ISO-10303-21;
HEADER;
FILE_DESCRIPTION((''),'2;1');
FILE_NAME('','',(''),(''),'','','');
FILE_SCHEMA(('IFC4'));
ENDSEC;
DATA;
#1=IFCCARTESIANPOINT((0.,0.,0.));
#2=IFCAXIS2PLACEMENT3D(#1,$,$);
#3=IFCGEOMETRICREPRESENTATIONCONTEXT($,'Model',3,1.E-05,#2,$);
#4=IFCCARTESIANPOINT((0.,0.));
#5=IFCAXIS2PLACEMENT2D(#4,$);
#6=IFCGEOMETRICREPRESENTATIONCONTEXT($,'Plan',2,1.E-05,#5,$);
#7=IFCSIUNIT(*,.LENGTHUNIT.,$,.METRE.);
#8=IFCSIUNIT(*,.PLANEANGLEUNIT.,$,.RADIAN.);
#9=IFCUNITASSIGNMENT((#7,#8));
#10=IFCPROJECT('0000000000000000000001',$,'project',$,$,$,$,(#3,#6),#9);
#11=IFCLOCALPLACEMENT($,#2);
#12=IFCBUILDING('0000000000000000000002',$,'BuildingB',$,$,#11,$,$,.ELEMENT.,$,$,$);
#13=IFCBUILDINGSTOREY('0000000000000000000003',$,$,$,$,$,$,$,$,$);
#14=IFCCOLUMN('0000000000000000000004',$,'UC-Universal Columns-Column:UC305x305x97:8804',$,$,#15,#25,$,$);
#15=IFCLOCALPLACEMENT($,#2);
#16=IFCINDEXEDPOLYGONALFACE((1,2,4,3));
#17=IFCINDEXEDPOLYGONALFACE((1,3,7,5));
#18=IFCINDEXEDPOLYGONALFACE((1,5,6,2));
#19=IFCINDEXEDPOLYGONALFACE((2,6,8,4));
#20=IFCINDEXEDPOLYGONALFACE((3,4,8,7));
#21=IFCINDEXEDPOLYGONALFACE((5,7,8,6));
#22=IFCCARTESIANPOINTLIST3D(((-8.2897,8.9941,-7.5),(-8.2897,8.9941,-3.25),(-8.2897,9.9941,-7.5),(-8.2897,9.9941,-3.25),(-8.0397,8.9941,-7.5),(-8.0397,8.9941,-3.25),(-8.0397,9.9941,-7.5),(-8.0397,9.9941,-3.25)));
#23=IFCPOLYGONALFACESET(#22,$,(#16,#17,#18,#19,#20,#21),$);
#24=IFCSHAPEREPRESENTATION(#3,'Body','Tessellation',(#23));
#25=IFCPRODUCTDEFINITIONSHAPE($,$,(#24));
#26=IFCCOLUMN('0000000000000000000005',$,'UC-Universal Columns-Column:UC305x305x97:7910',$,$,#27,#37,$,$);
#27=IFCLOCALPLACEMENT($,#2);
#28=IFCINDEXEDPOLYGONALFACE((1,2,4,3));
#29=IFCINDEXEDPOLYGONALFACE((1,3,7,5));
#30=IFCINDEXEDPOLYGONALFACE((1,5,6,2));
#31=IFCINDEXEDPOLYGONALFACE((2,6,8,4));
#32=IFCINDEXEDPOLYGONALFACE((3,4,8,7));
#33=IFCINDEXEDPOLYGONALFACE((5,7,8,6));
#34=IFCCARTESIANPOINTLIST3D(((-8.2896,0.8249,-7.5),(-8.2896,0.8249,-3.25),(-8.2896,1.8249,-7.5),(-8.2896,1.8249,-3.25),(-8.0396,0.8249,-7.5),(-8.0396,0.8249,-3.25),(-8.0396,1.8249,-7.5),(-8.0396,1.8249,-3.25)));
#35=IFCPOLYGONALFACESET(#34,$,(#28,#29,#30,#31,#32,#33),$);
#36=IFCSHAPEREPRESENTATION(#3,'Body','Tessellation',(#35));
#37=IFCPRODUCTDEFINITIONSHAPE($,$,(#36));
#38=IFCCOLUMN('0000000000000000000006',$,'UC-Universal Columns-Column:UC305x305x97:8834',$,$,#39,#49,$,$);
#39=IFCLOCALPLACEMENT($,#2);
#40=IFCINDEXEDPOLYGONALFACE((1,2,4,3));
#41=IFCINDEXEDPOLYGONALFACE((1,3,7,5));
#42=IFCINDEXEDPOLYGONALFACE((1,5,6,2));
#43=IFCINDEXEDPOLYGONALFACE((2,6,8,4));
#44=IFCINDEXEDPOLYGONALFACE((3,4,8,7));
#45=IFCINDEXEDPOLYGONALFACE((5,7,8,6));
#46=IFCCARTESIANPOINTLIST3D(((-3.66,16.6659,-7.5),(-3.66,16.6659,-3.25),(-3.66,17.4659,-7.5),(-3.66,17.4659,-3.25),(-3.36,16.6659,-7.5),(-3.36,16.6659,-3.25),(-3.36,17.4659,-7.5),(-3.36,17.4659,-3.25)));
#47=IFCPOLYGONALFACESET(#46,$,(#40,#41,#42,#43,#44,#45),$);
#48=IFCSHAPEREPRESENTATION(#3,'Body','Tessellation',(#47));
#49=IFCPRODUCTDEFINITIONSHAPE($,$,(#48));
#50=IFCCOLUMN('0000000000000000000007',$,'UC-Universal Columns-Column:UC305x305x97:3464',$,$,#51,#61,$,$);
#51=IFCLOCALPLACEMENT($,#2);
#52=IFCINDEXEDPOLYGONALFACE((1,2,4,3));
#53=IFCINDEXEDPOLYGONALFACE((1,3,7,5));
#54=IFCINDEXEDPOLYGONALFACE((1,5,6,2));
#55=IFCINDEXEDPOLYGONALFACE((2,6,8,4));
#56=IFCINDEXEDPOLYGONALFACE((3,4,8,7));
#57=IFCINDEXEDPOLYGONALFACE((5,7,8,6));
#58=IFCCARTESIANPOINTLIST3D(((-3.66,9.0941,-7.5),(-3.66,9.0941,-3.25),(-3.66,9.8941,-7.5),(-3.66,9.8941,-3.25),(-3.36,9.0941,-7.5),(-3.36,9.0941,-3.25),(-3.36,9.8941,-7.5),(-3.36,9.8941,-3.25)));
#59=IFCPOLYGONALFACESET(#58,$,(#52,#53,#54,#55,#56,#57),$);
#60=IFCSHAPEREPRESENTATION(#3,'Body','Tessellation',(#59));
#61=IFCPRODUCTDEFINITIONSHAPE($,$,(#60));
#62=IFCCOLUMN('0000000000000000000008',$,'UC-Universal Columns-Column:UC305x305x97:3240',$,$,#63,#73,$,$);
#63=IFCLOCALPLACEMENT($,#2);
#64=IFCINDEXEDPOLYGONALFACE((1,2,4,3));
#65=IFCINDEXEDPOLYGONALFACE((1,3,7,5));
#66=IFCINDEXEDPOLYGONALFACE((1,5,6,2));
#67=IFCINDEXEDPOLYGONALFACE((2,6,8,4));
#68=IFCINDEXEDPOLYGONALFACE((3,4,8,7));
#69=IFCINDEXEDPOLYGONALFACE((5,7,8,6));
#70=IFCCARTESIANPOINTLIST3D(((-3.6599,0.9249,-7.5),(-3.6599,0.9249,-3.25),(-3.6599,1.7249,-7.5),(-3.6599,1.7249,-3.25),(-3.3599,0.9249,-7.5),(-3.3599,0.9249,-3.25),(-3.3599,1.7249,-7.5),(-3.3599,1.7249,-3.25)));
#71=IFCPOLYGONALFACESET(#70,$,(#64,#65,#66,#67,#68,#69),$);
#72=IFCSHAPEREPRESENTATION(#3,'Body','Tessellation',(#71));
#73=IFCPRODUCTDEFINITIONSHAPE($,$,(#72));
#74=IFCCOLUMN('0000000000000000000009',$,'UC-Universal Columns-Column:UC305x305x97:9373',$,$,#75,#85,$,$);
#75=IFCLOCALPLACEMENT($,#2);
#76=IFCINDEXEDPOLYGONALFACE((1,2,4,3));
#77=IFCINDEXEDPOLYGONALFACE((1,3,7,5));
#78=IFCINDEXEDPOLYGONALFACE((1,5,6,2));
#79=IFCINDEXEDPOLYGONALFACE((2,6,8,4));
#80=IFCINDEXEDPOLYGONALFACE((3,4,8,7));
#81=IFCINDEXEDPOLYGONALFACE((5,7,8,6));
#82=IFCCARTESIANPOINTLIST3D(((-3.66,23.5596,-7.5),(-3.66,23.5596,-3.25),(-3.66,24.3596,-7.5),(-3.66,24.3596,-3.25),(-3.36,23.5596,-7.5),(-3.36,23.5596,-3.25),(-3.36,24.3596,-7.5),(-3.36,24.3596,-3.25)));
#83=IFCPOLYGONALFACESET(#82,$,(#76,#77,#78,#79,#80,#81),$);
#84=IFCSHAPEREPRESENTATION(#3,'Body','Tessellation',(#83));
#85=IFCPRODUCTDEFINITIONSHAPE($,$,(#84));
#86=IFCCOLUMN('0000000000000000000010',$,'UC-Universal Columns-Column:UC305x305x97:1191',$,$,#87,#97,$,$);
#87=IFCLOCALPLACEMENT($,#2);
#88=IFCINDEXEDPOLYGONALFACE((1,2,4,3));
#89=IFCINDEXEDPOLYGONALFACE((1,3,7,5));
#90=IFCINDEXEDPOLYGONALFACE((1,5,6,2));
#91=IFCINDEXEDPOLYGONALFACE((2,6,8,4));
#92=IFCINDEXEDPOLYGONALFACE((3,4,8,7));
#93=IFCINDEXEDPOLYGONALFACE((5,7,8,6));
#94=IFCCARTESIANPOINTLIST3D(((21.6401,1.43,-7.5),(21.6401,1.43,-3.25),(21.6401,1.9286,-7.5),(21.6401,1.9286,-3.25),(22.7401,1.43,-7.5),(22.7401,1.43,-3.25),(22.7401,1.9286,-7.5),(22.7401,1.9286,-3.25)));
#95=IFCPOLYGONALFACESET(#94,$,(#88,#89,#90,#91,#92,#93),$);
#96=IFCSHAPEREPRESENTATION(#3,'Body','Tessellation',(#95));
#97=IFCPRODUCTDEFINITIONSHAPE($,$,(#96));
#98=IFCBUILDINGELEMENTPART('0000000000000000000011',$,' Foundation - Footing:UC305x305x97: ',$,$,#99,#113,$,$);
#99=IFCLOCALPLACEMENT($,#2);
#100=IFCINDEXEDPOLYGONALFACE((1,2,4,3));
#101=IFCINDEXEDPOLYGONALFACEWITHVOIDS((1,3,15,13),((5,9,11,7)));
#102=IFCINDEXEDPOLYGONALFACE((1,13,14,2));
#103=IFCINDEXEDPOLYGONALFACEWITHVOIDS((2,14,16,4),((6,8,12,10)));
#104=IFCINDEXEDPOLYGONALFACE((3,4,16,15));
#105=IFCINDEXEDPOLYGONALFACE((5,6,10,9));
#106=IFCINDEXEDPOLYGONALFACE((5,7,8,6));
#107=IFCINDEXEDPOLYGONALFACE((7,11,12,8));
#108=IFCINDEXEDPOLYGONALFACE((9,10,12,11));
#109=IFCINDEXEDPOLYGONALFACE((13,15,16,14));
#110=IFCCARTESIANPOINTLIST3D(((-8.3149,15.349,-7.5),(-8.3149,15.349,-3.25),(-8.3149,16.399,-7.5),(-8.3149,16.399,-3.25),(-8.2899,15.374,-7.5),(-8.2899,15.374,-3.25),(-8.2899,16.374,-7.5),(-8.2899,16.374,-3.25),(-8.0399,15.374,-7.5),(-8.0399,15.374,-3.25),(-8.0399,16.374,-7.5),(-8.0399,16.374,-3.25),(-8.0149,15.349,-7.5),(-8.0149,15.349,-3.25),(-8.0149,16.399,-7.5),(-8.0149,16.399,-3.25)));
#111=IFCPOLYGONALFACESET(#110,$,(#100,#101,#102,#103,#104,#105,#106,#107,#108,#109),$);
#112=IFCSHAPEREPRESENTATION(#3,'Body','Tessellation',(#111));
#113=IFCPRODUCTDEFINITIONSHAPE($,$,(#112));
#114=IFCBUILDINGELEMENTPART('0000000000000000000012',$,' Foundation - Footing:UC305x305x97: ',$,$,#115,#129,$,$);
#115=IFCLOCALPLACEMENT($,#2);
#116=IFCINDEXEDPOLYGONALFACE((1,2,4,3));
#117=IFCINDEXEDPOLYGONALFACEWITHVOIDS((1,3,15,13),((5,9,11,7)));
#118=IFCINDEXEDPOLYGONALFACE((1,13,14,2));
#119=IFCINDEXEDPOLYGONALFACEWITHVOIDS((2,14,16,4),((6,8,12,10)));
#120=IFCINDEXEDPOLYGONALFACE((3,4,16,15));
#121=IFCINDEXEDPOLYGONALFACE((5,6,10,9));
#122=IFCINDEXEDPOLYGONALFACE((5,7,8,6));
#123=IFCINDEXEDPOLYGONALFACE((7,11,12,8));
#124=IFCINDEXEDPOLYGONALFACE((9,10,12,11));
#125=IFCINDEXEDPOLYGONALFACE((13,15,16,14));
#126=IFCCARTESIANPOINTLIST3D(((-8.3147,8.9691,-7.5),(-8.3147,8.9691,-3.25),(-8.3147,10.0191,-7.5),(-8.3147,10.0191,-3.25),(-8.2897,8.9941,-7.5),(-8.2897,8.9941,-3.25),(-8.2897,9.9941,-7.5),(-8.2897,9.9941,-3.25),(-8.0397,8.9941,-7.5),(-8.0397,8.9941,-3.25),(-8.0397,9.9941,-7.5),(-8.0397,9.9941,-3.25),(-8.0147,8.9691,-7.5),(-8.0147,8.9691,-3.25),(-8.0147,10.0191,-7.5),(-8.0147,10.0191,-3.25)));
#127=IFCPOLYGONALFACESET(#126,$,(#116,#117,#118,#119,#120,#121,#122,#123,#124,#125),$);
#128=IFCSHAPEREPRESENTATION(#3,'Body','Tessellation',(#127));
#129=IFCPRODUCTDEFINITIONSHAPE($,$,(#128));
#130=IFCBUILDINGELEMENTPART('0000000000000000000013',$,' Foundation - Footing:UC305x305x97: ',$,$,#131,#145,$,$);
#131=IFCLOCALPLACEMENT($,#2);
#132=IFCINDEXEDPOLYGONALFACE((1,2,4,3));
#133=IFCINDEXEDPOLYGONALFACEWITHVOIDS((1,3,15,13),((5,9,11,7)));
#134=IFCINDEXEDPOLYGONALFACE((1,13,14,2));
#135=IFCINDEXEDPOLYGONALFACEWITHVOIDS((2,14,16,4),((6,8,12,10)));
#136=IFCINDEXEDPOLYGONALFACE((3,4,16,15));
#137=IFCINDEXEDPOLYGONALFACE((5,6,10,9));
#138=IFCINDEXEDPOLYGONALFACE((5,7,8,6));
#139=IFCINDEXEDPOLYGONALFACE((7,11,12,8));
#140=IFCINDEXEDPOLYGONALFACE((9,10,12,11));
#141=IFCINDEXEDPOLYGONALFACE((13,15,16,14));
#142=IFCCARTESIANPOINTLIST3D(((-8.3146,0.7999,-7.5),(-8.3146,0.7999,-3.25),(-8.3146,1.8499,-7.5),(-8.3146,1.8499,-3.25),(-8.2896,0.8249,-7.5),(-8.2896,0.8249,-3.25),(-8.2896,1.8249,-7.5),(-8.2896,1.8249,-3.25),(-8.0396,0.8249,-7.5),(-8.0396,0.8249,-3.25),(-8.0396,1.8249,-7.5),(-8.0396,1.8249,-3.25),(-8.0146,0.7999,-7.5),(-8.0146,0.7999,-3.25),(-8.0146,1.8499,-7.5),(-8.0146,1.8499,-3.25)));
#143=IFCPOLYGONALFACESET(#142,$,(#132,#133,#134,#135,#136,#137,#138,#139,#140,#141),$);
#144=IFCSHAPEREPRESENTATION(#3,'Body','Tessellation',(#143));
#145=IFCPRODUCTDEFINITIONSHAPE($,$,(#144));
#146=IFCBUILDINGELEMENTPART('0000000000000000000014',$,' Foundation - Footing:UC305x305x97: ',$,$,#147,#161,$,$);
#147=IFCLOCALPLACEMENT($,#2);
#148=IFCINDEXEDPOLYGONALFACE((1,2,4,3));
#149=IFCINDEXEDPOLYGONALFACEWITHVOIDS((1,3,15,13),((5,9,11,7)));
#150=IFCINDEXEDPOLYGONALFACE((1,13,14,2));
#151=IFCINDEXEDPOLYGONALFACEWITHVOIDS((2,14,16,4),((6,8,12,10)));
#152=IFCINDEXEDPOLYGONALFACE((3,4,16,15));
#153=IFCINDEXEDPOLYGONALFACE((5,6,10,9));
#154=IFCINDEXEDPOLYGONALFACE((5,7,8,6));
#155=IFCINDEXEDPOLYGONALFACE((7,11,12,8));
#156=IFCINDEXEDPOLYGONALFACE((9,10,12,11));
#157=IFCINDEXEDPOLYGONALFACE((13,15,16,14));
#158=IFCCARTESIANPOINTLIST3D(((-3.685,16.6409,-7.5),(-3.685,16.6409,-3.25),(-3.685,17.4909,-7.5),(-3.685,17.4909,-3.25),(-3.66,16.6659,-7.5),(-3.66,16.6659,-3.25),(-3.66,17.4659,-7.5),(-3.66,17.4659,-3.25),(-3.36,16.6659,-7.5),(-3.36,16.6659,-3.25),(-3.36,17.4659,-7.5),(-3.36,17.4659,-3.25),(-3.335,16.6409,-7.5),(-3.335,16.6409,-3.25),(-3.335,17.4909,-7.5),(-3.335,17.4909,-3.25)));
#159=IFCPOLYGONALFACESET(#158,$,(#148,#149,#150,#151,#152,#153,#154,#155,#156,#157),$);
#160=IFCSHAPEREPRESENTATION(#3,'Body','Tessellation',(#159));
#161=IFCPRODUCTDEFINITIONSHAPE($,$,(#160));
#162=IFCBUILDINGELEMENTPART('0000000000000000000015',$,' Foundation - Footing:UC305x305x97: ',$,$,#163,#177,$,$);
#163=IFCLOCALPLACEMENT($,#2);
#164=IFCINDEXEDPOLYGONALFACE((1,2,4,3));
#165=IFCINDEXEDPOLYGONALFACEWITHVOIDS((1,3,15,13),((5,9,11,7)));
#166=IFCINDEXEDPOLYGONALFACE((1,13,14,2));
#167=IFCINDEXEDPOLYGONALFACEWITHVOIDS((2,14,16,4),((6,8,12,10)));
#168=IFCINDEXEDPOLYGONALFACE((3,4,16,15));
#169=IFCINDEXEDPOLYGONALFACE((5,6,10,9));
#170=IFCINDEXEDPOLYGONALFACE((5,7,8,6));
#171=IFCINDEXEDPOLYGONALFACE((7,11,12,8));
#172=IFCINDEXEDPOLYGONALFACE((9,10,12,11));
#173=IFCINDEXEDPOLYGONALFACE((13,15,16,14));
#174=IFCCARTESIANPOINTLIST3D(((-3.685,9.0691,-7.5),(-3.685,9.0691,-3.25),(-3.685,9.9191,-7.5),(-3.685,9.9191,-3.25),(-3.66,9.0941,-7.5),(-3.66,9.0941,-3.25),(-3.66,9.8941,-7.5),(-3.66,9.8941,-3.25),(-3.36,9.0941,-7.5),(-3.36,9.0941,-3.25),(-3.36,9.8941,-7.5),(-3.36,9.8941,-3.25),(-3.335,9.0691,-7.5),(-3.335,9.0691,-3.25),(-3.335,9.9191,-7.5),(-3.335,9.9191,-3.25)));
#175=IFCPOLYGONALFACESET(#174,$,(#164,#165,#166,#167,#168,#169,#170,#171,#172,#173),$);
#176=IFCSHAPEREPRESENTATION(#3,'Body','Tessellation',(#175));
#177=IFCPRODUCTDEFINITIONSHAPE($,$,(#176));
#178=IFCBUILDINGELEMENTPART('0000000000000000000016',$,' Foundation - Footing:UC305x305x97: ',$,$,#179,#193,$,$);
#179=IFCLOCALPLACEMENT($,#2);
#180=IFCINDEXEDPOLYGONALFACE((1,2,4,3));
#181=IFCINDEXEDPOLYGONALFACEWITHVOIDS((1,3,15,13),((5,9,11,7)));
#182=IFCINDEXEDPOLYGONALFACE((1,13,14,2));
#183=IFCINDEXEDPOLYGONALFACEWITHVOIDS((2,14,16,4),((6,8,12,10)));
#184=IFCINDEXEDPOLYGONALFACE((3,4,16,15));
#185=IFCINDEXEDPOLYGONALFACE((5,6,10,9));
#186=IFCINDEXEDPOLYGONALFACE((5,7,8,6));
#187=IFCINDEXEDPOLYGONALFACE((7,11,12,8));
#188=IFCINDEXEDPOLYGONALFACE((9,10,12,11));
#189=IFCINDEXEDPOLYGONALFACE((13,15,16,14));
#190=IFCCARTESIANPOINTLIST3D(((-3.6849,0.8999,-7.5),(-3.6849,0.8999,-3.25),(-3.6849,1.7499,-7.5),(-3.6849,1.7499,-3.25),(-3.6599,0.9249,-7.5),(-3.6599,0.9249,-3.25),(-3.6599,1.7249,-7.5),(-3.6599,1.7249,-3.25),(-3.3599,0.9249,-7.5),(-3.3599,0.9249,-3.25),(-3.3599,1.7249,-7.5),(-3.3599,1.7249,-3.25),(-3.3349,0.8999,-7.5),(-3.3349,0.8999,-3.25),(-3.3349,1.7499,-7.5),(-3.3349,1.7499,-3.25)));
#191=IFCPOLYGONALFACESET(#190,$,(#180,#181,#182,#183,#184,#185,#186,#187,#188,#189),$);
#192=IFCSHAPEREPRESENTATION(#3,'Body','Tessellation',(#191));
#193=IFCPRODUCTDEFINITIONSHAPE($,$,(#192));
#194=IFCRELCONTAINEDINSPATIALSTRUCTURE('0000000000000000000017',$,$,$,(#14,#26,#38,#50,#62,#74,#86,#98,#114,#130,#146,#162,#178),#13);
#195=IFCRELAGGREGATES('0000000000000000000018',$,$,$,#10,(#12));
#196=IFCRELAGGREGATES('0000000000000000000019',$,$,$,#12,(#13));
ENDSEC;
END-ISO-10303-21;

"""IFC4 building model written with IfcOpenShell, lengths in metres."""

from ifc_helpers import new_model, si_unit, origin, origin_2d, place, context, project, spatial, polyline, outline, extrude, element, save


model = new_model("IFC4")

# Units and contexts
model_context = context("Model", 3, precision=1e-05, world=origin())
plan_context = context("Plan", 2, precision=1e-05, world=origin_2d())
ifc_project = project(units=[si_unit("LENGTHUNIT", "METRE"), si_unit("PLANEANGLEUNIT", "RADIAN")], contexts=[model_context, plan_context])

# Building, storey
building_placement = place(None, origin())
building = spatial("IfcBuilding", under=ifc_project, at=building_placement, Name="BuildingB", CompositionType="ELEMENT")
storey = spatial("IfcBuildingStorey", under=building)

# Columns
element("IfcColumn", 1, inside=storey, Name="UC-Universal Columns-Column:UC305x305x97:8804", context=model_context, shape_type="SweptSolid", body=[
    extrude(outline(polyline([(-8.0397, 9.9941, -7.5), (-8.2897, 9.9941, -7.5), (-8.2897, 8.9941, -7.5), (-8.0397, 8.9941, -7.5), (-8.0397, 9.9941, -7.5)])), None, (0.0, 0.0, 1.0), 4.25),
])
element("IfcColumn", 2, inside=storey, Name="UC-Universal Columns-Column:UC305x305x97:7910", context=model_context, shape_type="SweptSolid", body=[
    extrude(outline(polyline([(-8.0396, 1.8249, -7.5), (-8.2896, 1.8249, -7.5), (-8.2896, 0.8249, -7.5), (-8.0396, 0.8249, -7.5), (-8.0396, 1.8249, -7.5)])), None, (0.0, 0.0, 1.0), 4.25),
])
element("IfcColumn", 3, inside=storey, Name="UC-Universal Columns-Column:UC305x305x97:8834", context=model_context, shape_type="SweptSolid", body=[
    extrude(outline(polyline([(-3.36, 17.4659, -7.5), (-3.66, 17.4659, -7.5), (-3.66, 16.6659, -7.5), (-3.36, 16.6659, -7.5), (-3.36, 17.4659, -7.5)])), None, (0.0, 0.0, 1.0), 4.25),
])
element("IfcColumn", 4, inside=storey, Name="UC-Universal Columns-Column:UC305x305x97:3464", context=model_context, shape_type="SweptSolid", body=[
    extrude(outline(polyline([(-3.36, 9.8941, -7.5), (-3.66, 9.8941, -7.5), (-3.66, 9.0941, -7.5), (-3.36, 9.0941, -7.5), (-3.36, 9.8941, -7.5)])), None, (0.0, 0.0, 1.0), 4.25),
])
element("IfcColumn", 5, inside=storey, Name="UC-Universal Columns-Column:UC305x305x97:3240", context=model_context, shape_type="SweptSolid", body=[
    extrude(outline(polyline([(-3.3599, 1.7249, -7.5), (-3.6599, 1.7249, -7.5), (-3.6599, 0.9249, -7.5), (-3.3599, 0.9249, -7.5), (-3.3599, 1.7249, -7.5)])), None, (0.0, 0.0, 1.0), 4.25),
])
element("IfcColumn", 6, inside=storey, Name="UC-Universal Columns-Column:UC305x305x97:9373", context=model_context, shape_type="SweptSolid", body=[
    extrude(outline(polyline([(-3.66, 23.5596, -7.5), (-3.36, 23.5596, -7.5), (-3.36, 24.3596, -7.5), (-3.66, 24.3596, -7.5), (-3.66, 23.5596, -7.5)])), None, (0.0, 0.0, 1.0), 4.25),
])
element("IfcColumn", 7, inside=storey, Name="UC-Universal Columns-Column:UC305x305x97:1191", context=model_context, shape_type="SweptSolid", body=[
    extrude(outline(polyline([(21.6401, 1.43, -7.5), (22.7401, 1.43, -7.5), (22.7401, 1.9286, -7.5), (21.6401, 1.9286, -7.5), (21.6401, 1.43, -7.5)])), None, (0.0, 0.0, 1.0), 4.25),
])

# Building element parts, openings
building_element_part_1 = element("IfcBuildingElementPart", 8, inside=storey, Name=" Foundation - Footing:UC305x305x97: ", context=model_context, shape_type="SweptSolid", body=[
    extrude(outline(polyline([(-8.0149, 16.399, -7.5), (-8.3149, 16.399, -7.5), (-8.3149, 15.349, -7.5), (-8.0149, 15.349, -7.5), (-8.0149, 16.399, -7.5)])), None, (0.0, 0.0, 1.0), 4.25),
])
element("IfcOpeningElement", 9, inside=storey, cuts=building_element_part_1, context=model_context, shape_type="SweptSolid", body=[
    extrude(outline(polyline([(-8.0399, 16.374, -7.5), (-8.2899, 16.374, -7.5), (-8.2899, 15.374, -7.5), (-8.0399, 15.374, -7.5), (-8.0399, 16.374, -7.5)])), None, (0.0, 0.0, 1.0), 4.25),
])
building_element_part_2 = element("IfcBuildingElementPart", 10, inside=storey, Name=" Foundation - Footing:UC305x305x97: ", context=model_context, shape_type="SweptSolid", body=[
    extrude(outline(polyline([(-8.0147, 10.0191, -7.5), (-8.3147, 10.0191, -7.5), (-8.3147, 8.9691, -7.5), (-8.0147, 8.9691, -7.5), (-8.0147, 10.0191, -7.5)])), None, (0.0, 0.0, 1.0), 4.25),
])
element("IfcOpeningElement", 11, inside=storey, cuts=building_element_part_2, context=model_context, shape_type="SweptSolid", body=[
    extrude(outline(polyline([(-8.0397, 9.9941, -7.5), (-8.2897, 9.9941, -7.5), (-8.2897, 8.9941, -7.5), (-8.0397, 8.9941, -7.5), (-8.0397, 9.9941, -7.5)])), None, (0.0, 0.0, 1.0), 4.25),
])
building_element_part_3 = element("IfcBuildingElementPart", 12, inside=storey, Name=" Foundation - Footing:UC305x305x97: ", context=model_context, shape_type="SweptSolid", body=[
    extrude(outline(polyline([(-8.0146, 1.8499, -7.5), (-8.3146, 1.8499, -7.5), (-8.3146, 0.7999, -7.5), (-8.0146, 0.7999, -7.5), (-8.0146, 1.8499, -7.5)])), None, (0.0, 0.0, 1.0), 4.25),
])
element("IfcOpeningElement", 13, inside=storey, cuts=building_element_part_3, context=model_context, shape_type="SweptSolid", body=[
    extrude(outline(polyline([(-8.0396, 1.8249, -7.5), (-8.2896, 1.8249, -7.5), (-8.2896, 0.8249, -7.5), (-8.0396, 0.8249, -7.5), (-8.0396, 1.8249, -7.5)])), None, (0.0, 0.0, 1.0), 4.25),
])
building_element_part_4 = element("IfcBuildingElementPart", 14, inside=storey, Name=" Foundation - Footing:UC305x305x97: ", context=model_context, shape_type="SweptSolid", body=[
    extrude(outline(polyline([(-3.335, 17.4909, -7.5), (-3.685, 17.4909, -7.5), (-3.685, 16.6409, -7.5), (-3.335, 16.6409, -7.5), (-3.335, 17.4909, -7.5)])), None, (0.0, 0.0, 1.0), 4.25),
])
element("IfcOpeningElement", 15, inside=storey, cuts=building_element_part_4, context=model_context, shape_type="SweptSolid", body=[
    extrude(outline(polyline([(-3.36, 17.4659, -7.5), (-3.66, 17.4659, -7.5), (-3.66, 16.6659, -7.5), (-3.36, 16.6659, -7.5), (-3.36, 17.4659, -7.5)])), None, (0.0, 0.0, 1.0), 4.25),
])
building_element_part_5 = element("IfcBuildingElementPart", 16, inside=storey, Name=" Foundation - Footing:UC305x305x97: ", context=model_context, shape_type="SweptSolid", body=[
    extrude(outline(polyline([(-3.335, 9.9191, -7.5), (-3.685, 9.9191, -7.5), (-3.685, 9.0691, -7.5), (-3.335, 9.0691, -7.5), (-3.335, 9.9191, -7.5)])), None, (0.0, 0.0, 1.0), 4.25),
])
element("IfcOpeningElement", 17, inside=storey, cuts=building_element_part_5, context=model_context, shape_type="SweptSolid", body=[
    extrude(outline(polyline([(-3.36, 9.8941, -7.5), (-3.66, 9.8941, -7.5), (-3.66, 9.0941, -7.5), (-3.36, 9.0941, -7.5), (-3.36, 9.8941, -7.5)])), None, (0.0, 0.0, 1.0), 4.25),
])
building_element_part_6 = element("IfcBuildingElementPart", 18, inside=storey, Name=" Foundation - Footing:UC305x305x97: ", context=model_context, shape_type="SweptSolid", body=[
    extrude(outline(polyline([(-3.3349, 1.7499, -7.5), (-3.6849, 1.7499, -7.5), (-3.6849, 0.8999, -7.5), (-3.3349, 0.8999, -7.5), (-3.3349, 1.7499, -7.5)])), None, (0.0, 0.0, 1.0), 4.25),
])
element("IfcOpeningElement", 19, inside=storey, cuts=building_element_part_6, context=model_context, shape_type="SweptSolid", body=[
    extrude(outline(polyline([(-3.3599, 1.7249, -7.5), (-3.6599, 1.7249, -7.5), (-3.6599, 0.9249, -7.5), (-3.3599, 0.9249, -7.5), (-3.3599, 1.7249, -7.5)])), None, (0.0, 0.0, 1.0), 4.25),
])

save(model, "model.ifc")
